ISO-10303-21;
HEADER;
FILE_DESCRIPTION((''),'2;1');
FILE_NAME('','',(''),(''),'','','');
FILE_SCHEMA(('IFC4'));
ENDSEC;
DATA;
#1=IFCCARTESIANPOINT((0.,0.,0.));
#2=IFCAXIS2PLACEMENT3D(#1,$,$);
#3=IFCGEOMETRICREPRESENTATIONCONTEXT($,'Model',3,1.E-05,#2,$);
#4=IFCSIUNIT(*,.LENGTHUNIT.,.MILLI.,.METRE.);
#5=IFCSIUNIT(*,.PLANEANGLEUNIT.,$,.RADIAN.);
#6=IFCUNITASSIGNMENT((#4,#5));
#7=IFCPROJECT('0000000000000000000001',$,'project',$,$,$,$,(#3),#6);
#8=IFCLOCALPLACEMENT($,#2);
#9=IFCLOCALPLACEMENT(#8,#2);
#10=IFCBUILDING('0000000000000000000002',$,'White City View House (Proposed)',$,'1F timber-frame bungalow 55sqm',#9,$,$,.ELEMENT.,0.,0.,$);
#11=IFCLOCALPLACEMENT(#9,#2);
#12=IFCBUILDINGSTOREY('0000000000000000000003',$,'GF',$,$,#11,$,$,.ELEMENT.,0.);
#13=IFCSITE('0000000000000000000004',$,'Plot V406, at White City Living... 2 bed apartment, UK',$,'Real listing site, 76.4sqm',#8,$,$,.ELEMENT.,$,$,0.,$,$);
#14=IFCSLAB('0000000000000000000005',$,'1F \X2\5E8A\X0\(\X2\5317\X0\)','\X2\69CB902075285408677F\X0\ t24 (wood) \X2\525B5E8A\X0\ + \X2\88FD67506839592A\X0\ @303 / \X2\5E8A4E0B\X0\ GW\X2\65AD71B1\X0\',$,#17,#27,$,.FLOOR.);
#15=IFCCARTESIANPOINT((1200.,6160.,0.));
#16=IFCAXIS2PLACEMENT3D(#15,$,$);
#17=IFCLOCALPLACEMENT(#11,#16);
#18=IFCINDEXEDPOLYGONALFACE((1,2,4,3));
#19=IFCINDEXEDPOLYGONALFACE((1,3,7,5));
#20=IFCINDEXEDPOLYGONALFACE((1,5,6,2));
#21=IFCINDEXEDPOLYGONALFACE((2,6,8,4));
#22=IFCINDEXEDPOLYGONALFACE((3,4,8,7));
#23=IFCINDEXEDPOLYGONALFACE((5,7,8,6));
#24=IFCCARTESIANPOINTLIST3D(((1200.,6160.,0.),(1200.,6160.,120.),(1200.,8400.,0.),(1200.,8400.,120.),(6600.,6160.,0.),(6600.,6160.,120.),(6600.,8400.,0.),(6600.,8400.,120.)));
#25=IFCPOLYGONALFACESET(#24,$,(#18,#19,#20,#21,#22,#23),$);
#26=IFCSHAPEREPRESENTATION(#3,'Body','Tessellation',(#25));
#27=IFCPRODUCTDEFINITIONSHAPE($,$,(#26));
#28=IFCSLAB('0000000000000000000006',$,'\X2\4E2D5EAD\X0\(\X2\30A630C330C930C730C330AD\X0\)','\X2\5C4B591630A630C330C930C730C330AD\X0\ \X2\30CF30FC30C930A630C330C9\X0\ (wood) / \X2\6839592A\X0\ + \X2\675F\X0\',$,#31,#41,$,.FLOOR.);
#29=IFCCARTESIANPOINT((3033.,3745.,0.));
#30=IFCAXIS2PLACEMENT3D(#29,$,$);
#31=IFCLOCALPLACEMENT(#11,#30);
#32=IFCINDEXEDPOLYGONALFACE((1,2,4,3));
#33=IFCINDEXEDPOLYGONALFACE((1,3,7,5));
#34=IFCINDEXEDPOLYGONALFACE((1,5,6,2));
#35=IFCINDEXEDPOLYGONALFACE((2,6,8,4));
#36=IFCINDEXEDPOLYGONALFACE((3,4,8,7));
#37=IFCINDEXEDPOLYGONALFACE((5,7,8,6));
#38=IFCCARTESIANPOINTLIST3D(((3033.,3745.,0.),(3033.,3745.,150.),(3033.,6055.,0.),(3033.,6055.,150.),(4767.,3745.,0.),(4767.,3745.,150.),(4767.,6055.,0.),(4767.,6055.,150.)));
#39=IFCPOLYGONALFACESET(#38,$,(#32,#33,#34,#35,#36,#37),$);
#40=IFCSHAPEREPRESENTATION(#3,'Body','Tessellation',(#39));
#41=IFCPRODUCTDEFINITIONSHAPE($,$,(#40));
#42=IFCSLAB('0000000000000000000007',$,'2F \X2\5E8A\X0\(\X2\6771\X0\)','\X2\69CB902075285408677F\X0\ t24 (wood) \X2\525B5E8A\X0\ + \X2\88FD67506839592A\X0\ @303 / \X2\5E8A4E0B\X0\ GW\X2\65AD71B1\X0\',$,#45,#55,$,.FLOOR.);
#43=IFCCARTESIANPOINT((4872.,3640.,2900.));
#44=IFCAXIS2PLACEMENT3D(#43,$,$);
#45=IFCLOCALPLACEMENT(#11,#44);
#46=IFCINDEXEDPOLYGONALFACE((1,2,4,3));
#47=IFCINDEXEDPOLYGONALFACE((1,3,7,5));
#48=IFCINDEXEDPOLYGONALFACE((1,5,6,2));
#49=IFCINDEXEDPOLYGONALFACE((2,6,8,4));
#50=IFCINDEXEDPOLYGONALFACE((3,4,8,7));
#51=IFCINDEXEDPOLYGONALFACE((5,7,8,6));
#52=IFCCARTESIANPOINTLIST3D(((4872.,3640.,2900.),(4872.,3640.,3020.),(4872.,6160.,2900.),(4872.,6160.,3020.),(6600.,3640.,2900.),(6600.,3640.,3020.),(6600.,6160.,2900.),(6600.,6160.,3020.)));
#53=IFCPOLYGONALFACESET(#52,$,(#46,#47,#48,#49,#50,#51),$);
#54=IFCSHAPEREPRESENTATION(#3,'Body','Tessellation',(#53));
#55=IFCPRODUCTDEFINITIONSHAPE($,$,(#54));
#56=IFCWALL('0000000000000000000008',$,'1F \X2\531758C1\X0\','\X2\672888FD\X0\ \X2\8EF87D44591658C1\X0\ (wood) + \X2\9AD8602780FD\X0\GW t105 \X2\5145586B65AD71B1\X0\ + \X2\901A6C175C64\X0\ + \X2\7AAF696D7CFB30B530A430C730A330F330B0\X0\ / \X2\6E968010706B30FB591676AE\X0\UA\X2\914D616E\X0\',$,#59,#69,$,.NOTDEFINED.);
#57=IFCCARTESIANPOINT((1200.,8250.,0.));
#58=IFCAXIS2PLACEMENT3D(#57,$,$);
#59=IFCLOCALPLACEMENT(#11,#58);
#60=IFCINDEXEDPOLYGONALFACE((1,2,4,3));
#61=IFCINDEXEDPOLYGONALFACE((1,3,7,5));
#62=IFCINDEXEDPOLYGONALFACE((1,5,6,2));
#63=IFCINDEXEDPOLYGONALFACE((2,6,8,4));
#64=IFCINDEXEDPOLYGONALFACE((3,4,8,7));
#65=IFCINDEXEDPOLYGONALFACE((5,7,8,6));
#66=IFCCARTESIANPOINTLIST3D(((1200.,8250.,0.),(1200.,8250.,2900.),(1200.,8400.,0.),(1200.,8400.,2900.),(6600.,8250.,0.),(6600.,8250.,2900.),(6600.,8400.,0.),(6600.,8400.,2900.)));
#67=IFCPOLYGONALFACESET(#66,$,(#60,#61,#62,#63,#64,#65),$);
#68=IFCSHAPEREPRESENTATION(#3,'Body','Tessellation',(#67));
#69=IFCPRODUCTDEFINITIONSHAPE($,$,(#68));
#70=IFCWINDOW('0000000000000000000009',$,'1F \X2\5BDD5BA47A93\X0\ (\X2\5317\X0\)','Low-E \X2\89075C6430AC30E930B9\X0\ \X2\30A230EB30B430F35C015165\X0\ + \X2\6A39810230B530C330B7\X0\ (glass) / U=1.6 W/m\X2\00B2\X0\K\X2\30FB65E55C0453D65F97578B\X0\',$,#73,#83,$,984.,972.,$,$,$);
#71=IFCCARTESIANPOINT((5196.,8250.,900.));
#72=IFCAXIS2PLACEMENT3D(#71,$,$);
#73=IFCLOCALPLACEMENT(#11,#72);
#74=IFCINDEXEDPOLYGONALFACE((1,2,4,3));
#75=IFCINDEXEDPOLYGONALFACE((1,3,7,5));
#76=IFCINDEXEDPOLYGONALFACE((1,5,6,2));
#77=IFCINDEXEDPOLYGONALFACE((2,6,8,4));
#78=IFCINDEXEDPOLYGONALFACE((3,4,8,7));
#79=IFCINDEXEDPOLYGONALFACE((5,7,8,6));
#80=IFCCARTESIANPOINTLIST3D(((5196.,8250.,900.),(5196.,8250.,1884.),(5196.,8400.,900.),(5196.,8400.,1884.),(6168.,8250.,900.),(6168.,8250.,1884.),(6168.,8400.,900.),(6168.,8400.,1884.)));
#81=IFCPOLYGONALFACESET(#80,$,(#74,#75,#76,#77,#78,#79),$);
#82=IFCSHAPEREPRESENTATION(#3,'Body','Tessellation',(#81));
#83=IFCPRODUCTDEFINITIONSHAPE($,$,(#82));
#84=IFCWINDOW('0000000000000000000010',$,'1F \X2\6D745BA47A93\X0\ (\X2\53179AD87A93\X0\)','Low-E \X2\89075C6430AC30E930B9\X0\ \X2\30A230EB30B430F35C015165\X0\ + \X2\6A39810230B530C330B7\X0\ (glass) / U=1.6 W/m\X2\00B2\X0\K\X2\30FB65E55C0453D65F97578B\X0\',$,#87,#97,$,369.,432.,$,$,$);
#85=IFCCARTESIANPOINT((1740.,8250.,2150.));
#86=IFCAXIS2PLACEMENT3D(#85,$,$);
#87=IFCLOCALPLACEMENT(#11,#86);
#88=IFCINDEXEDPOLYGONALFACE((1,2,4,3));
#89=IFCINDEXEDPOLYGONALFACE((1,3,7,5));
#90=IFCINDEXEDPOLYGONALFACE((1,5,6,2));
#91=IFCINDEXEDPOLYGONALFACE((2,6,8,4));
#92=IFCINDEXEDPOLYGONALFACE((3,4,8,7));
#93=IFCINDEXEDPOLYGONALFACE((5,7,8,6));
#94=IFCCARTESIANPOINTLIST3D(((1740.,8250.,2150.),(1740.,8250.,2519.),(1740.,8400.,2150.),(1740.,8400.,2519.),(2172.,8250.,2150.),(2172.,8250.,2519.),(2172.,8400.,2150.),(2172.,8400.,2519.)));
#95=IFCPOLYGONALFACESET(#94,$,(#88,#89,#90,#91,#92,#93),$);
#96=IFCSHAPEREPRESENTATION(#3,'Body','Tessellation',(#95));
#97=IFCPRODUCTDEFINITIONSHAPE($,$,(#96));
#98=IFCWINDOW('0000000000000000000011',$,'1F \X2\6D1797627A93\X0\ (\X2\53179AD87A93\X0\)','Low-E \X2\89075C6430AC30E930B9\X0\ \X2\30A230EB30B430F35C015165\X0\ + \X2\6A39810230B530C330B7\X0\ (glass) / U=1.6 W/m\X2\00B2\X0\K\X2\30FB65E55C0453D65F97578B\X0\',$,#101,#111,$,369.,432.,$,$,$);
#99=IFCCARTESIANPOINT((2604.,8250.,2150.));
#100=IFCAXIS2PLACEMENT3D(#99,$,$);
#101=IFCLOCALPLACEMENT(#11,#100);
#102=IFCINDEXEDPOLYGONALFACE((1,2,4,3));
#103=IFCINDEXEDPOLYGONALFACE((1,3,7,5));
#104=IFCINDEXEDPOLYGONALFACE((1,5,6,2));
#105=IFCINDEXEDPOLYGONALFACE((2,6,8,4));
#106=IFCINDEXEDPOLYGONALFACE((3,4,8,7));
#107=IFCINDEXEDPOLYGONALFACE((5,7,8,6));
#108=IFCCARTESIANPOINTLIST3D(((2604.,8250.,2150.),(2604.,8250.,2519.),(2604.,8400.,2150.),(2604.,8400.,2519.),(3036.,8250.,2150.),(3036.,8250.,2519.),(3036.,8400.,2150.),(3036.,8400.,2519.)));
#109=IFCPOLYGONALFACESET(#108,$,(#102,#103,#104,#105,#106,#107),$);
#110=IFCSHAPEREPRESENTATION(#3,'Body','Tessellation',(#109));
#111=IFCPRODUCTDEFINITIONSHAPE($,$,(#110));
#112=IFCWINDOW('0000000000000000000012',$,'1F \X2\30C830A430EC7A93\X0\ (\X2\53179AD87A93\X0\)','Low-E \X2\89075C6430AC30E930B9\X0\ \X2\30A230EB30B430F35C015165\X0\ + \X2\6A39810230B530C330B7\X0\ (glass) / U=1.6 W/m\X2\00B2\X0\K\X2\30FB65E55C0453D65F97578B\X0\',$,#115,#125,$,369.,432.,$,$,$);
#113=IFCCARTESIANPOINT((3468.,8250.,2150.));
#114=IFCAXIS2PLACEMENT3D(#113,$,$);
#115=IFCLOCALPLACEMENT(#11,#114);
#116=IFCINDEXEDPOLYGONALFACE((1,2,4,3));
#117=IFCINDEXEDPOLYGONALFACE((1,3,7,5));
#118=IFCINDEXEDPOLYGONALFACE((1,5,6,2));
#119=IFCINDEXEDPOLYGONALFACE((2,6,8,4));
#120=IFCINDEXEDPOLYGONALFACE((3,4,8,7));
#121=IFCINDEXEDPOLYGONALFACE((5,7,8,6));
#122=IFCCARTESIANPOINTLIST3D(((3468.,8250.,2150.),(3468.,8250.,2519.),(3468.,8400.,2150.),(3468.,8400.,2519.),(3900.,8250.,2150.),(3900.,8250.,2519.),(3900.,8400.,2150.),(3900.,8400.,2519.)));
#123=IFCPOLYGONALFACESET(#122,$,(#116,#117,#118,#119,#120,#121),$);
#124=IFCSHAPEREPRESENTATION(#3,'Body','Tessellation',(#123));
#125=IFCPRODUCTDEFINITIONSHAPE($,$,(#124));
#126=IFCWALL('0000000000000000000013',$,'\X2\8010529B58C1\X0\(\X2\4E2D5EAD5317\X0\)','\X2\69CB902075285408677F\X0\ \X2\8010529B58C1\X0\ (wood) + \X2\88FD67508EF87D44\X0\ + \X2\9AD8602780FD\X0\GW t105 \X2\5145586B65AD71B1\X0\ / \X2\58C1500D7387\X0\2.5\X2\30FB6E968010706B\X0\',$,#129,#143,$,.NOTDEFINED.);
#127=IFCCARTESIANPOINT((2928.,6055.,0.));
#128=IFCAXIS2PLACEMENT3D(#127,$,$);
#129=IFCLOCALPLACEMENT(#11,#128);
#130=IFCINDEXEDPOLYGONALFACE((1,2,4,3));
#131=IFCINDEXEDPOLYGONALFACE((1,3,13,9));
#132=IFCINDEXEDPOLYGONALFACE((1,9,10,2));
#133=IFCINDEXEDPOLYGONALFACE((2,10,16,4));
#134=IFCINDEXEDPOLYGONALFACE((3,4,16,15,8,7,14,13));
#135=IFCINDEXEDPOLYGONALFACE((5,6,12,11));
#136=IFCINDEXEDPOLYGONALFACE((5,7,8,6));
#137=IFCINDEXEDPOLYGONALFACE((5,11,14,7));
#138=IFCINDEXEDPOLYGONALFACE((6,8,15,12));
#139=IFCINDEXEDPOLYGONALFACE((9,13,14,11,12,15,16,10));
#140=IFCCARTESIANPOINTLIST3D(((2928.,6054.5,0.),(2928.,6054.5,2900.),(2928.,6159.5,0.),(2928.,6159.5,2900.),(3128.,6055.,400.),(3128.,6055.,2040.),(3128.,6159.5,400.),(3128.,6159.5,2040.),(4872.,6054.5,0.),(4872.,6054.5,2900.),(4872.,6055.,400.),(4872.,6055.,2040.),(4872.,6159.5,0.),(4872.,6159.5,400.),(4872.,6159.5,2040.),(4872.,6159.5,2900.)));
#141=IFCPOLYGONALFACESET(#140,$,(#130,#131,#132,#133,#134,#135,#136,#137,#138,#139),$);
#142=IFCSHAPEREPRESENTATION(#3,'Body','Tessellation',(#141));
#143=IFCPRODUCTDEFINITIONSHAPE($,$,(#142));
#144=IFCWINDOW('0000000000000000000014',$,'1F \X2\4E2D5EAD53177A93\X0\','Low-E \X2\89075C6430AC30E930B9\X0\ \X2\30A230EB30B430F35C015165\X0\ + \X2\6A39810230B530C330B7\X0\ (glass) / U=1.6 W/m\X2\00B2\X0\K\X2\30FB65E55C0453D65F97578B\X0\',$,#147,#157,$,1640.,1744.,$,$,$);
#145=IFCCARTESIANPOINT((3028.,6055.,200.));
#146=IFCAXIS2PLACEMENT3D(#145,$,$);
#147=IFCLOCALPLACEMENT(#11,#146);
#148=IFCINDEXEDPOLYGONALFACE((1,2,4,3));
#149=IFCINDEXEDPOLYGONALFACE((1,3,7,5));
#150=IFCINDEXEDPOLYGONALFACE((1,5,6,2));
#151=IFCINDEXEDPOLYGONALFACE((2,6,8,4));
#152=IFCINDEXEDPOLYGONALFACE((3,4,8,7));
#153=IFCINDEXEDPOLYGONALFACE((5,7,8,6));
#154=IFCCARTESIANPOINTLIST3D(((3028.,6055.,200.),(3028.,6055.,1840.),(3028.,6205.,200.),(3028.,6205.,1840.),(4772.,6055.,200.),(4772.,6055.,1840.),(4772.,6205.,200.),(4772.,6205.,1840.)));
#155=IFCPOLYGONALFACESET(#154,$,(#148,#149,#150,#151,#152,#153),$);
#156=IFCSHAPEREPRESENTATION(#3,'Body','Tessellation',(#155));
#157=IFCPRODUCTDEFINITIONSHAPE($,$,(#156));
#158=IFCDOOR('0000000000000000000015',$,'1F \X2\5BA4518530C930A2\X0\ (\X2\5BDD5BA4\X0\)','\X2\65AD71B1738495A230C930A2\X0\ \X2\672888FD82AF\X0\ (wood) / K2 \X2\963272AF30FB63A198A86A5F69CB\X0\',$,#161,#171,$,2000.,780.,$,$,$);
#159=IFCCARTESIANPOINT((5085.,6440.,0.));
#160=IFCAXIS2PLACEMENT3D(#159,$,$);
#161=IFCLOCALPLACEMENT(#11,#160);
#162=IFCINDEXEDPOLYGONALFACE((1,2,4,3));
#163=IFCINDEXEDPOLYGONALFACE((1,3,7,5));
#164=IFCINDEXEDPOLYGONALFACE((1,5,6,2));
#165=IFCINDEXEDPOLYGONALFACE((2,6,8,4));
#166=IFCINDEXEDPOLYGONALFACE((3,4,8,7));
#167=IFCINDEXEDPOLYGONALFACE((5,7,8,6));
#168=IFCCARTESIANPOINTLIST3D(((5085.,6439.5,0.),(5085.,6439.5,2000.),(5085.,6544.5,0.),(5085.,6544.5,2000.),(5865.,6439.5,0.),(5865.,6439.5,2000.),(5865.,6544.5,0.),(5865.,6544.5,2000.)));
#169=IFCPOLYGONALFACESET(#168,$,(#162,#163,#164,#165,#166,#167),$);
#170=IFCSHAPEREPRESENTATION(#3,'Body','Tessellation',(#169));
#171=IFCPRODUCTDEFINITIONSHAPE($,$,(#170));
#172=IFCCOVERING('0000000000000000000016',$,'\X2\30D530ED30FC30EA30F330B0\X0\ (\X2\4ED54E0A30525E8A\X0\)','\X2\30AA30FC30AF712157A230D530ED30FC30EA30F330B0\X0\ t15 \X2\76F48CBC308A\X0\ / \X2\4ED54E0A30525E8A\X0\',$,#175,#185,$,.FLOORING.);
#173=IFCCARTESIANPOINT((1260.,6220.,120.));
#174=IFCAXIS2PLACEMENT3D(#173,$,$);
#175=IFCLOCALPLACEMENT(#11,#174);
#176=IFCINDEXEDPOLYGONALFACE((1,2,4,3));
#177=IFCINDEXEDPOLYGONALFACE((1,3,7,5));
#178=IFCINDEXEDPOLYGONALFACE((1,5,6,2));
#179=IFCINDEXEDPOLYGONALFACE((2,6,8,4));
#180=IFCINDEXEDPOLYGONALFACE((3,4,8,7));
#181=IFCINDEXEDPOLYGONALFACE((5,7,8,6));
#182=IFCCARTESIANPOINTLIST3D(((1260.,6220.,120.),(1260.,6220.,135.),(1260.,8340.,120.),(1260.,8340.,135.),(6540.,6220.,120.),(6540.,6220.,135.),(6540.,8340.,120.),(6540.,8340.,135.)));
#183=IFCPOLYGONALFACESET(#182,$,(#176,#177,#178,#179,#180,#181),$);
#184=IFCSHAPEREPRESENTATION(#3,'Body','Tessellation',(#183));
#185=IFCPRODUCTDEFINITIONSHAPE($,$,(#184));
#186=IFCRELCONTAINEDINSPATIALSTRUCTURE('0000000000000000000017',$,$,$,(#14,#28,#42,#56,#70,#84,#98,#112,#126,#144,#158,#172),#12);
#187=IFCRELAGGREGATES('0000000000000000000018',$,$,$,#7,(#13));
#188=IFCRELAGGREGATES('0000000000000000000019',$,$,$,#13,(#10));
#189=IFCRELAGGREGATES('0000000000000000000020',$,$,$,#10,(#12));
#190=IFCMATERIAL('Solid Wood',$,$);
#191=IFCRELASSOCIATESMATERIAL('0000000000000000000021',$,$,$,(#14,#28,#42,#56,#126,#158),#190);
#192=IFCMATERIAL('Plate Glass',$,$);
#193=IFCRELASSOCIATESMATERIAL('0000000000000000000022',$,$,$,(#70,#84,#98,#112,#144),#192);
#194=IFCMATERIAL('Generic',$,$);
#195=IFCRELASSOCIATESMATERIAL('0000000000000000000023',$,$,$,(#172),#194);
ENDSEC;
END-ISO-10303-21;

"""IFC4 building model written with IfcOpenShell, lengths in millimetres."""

from ifc_helpers import new_model, si_unit, frame, frame_2d, origin, place, context, project, spatial, rectangle, extrude, material, element, fill, save


model = new_model("IFC4")

# Units and contexts
model_context = context("Model", 3, precision=1e-05, world=origin())
ifc_project = project(units=[si_unit("LENGTHUNIT", "METRE", prefix="MILLI"), si_unit("PLANEANGLEUNIT", "RADIAN")], contexts=[model_context])

# Site, building, storey
site_placement = place(None, origin())
site = spatial("IfcSite", under=ifc_project, at=site_placement, Name="Plot V406, at White City Living... 2 bed apartment, UK", ObjectType="Real listing site, 76.4sqm", CompositionType="ELEMENT", RefElevation=0.0)
building_placement = place(site_placement, origin())
building = spatial("IfcBuilding", under=site, at=building_placement, Name="White City View House (Proposed)", ObjectType="1F timber-frame bungalow 55sqm", CompositionType="ELEMENT", ElevationOfRefHeight=0.0, ElevationOfTerrain=0.0)
storey_placement = place(building_placement, origin())
storey = spatial("IfcBuildingStorey", under=building, at=storey_placement, Name="GF", CompositionType="ELEMENT", Elevation=0.0)

# Slabs
ifc_material_1 = material(Name="Solid Wood")
slab_1_placement = place(storey_placement, frame((1200.0, 6160.0, 0.0)))
element("IfcSlab", 1, at=slab_1_placement, inside=storey, material=ifc_material_1, Name="1F 床(北)", Description="構造用合板 t24 (wood) 剛床 + 製材根太 @303 / 床下 GW断熱", PredefinedType="FLOOR", context=model_context, shape_type="SweptSolid", body=[
    extrude(rectangle(XDim=5400.0, YDim=2240.0, at=frame_2d((2700.0, 1120.0))), frame((1200.0, 6160.0, 0.0)), (0.0, 0.0, 1.0), 120.0),
])
slab_2_placement = place(storey_placement, frame((3033.0, 3745.0, 0.0)))
element("IfcSlab", 2, at=slab_2_placement, inside=storey, material=ifc_material_1, Name="中庭(ウッドデッキ)", Description="屋外ウッドデッキ ハードウッド (wood) / 根太 + 束", PredefinedType="FLOOR", context=model_context, shape_type="SweptSolid", body=[
    extrude(rectangle(XDim=1734.0, YDim=2310.0, at=frame_2d((867.0, 1155.0))), frame((3033.0, 3745.0, 0.0)), (0.0, 0.0, 1.0), 150.0),
])
slab_3_placement = place(storey_placement, frame((4872.0, 3640.0, 2900.0)))
element("IfcSlab", 3, at=slab_3_placement, inside=storey, material=ifc_material_1, Name="2F 床(東)", Description="構造用合板 t24 (wood) 剛床 + 製材根太 @303 / 床下 GW断熱", PredefinedType="FLOOR", context=model_context, shape_type="SweptSolid", body=[
    extrude(rectangle(XDim=1728.0, YDim=2520.0, at=frame_2d((864.0, 1260.0))), frame((4872.0, 3640.0, 2900.0)), (0.0, 0.0, 1.0), 120.0),
])

# Wall, openings, windows
wall_1_placement = place(storey_placement, frame((1200.0, 8250.0, 0.0)))
wall_1 = element("IfcWall", 4, at=wall_1_placement, inside=storey, material=ifc_material_1, Name="1F 北壁", Description="木製 軸組外壁 (wood) + 高性能GW t105 充填断熱 + 通気層 + 窯業系サイディング / 準耐火・外皮UA配慮", PredefinedType="NOTDEFINED", context=model_context, shape_type="SweptSolid", body=[
    extrude(rectangle(XDim=5400.0, YDim=150.0, at=frame_2d((2700.0, 75.0))), frame((1200.0, 8250.0, 0.0)), (0.0, 0.0, 1.0), 2900.0),
])
opening_1_placement = place(storey_placement, frame((5196.0, 8250.0, 900.0)))
opening_1 = element("IfcOpeningElement", 5, at=opening_1_placement, cuts=wall_1, PredefinedType="NOTDEFINED", context=model_context, shape_type="SweptSolid", body=[
    extrude(rectangle(XDim=972.0, YDim=150.0, at=frame_2d((486.0, 75.0))), frame((5196.0, 8250.0, 900.0)), (0.0, 0.0, 1.0), 984.0),
])
opening_2_placement = place(storey_placement, frame((1740.0, 8250.0, 2150.0)))
opening_2 = element("IfcOpeningElement", 6, at=opening_2_placement, cuts=wall_1, PredefinedType="NOTDEFINED", context=model_context, shape_type="SweptSolid", body=[
    extrude(rectangle(XDim=432.0, YDim=150.0, at=frame_2d((216.0, 75.0))), frame((1740.0, 8250.0, 2150.0)), (0.0, 0.0, 1.0), 369.0),
])
opening_3_placement = place(storey_placement, frame((2604.0, 8250.0, 2150.0)))
opening_3 = element("IfcOpeningElement", 7, at=opening_3_placement, cuts=wall_1, PredefinedType="NOTDEFINED", context=model_context, shape_type="SweptSolid", body=[
    extrude(rectangle(XDim=432.0, YDim=150.0, at=frame_2d((216.0, 75.0))), frame((2604.0, 8250.0, 2150.0)), (0.0, 0.0, 1.0), 369.0),
])
opening_4_placement = place(storey_placement, frame((3468.0, 8250.0, 2150.0)))
opening_4 = element("IfcOpeningElement", 8, at=opening_4_placement, cuts=wall_1, PredefinedType="NOTDEFINED", context=model_context, shape_type="SweptSolid", body=[
    extrude(rectangle(XDim=432.0, YDim=150.0, at=frame_2d((216.0, 75.0))), frame((3468.0, 8250.0, 2150.0)), (0.0, 0.0, 1.0), 369.0),
])
ifc_material_2 = material(Name="Plate Glass")
window_1_placement = place(storey_placement, frame((5196.0, 8250.0, 900.0)))
window_1 = element("IfcWindow", 9, at=window_1_placement, inside=storey, material=ifc_material_2, Name="1F 寝室窓 (北)", Description="Low-E 複層ガラス アルゴン封入 + 樹脂サッシ (glass) / U=1.6 W/m²K・日射取得型", OverallHeight=984.0, OverallWidth=972.0, context=model_context, shape_type="SweptSolid", body=[
    extrude(rectangle(XDim=972.0, YDim=150.0, at=frame_2d((486.0, 75.0))), frame((5196.0, 8250.0, 900.0)), (0.0, 0.0, 1.0), 984.0),
])
fill(opening_1, window_1)
window_2_placement = place(storey_placement, frame((1740.0, 8250.0, 2150.0)))
window_2 = element("IfcWindow", 10, at=window_2_placement, inside=storey, material=ifc_material_2, Name="1F 浴室窓 (北高窓)", Description="Low-E 複層ガラス アルゴン封入 + 樹脂サッシ (glass) / U=1.6 W/m²K・日射取得型", OverallHeight=369.0, OverallWidth=432.0, context=model_context, shape_type="SweptSolid", body=[
    extrude(rectangle(XDim=432.0, YDim=150.0, at=frame_2d((216.0, 75.0))), frame((1740.0, 8250.0, 2150.0)), (0.0, 0.0, 1.0), 369.0),
])
fill(opening_2, window_2)
window_3_placement = place(storey_placement, frame((2604.0, 8250.0, 2150.0)))
window_3 = element("IfcWindow", 11, at=window_3_placement, inside=storey, material=ifc_material_2, Name="1F 洗面窓 (北高窓)", Description="Low-E 複層ガラス アルゴン封入 + 樹脂サッシ (glass) / U=1.6 W/m²K・日射取得型", OverallHeight=369.0, OverallWidth=432.0, context=model_context, shape_type="SweptSolid", body=[
    extrude(rectangle(XDim=432.0, YDim=150.0, at=frame_2d((216.0, 75.0))), frame((2604.0, 8250.0, 2150.0)), (0.0, 0.0, 1.0), 369.0),
])
fill(opening_3, window_3)
window_4_placement = place(storey_placement, frame((3468.0, 8250.0, 2150.0)))
window_4 = element("IfcWindow", 12, at=window_4_placement, inside=storey, material=ifc_material_2, Name="1F トイレ窓 (北高窓)", Description="Low-E 複層ガラス アルゴン封入 + 樹脂サッシ (glass) / U=1.6 W/m²K・日射取得型", OverallHeight=369.0, OverallWidth=432.0, context=model_context, shape_type="SweptSolid", body=[
    extrude(rectangle(XDim=432.0, YDim=150.0, at=frame_2d((216.0, 75.0))), frame((3468.0, 8250.0, 2150.0)), (0.0, 0.0, 1.0), 369.0),
])
fill(opening_4, window_4)

# Wall, opening, window
wall_2_placement = place(storey_placement, frame((2928.0, 6055.0, 0.0)))
wall_2 = element("IfcWall", 13, at=wall_2_placement, inside=storey, material=ifc_material_1, Name="耐力壁(中庭北)", Description="構造用合板 耐力壁 (wood) + 製材軸組 + 高性能GW t105 充填断熱 / 壁倍率2.5・準耐火", PredefinedType="NOTDEFINED", context=model_context, shape_type="SweptSolid", body=[
    extrude(rectangle(XDim=1944.0, YDim=105.0, at=frame_2d((972.0, 52.0))), frame((2928.0, 6055.0, 0.0)), (0.0, 0.0, 1.0), 2900.0),
])
opening_5_placement = place(storey_placement, frame((3028.0, 6055.0, 200.0)))
opening_5 = element("IfcOpeningElement", 14, at=opening_5_placement, cuts=wall_2, PredefinedType="NOTDEFINED", context=model_context, shape_type="SweptSolid", body=[
    extrude(rectangle(XDim=1744.0, YDim=150.0, at=frame_2d((872.0, 75.0))), frame((3028.0, 6055.0, 200.0)), (0.0, 0.0, 1.0), 1640.0),
])
window_5_placement = place(storey_placement, frame((3028.0, 6055.0, 200.0)))
window_5 = element("IfcWindow", 15, at=window_5_placement, inside=storey, material=ifc_material_2, Name="1F 中庭北窓", Description="Low-E 複層ガラス アルゴン封入 + 樹脂サッシ (glass) / U=1.6 W/m²K・日射取得型", OverallHeight=1640.0, OverallWidth=1744.0, context=model_context, shape_type="SweptSolid", body=[
    extrude(rectangle(XDim=1744.0, YDim=150.0, at=frame_2d((872.0, 75.0))), frame((3028.0, 6055.0, 200.0)), (0.0, 0.0, 1.0), 1640.0),
])
fill(opening_5, window_5)

# Door
door_1_placement = place(storey_placement, frame((5085.0, 6440.0, 0.0)))
element("IfcDoor", 16, at=door_1_placement, inside=storey, material=ifc_material_1, Name="1F 室内ドア (寝室)", Description="断熱玄関ドア 木製芯 (wood) / K2 防犯・採風機構", OverallHeight=2000.0, OverallWidth=780.0, context=model_context, shape_type="SweptSolid", body=[
    extrude(rectangle(XDim=780.0, YDim=105.0, at=frame_2d((390.0, 52.0))), frame((5085.0, 6440.0, 0.0)), (0.0, 0.0, 1.0), 2000.0),
])

# Covering
ifc_material_3 = material(Name="Generic")
covering_1_placement = place(storey_placement, frame((1260.0, 6220.0, 120.0)))
element("IfcCovering", 17, at=covering_1_placement, inside=storey, material=ifc_material_3, Name="フローリング (仕上げ床)", Description="オーク無垢フローリング t15 直貼り / 仕上げ床", PredefinedType="FLOORING", context=model_context, shape_type="SweptSolid", body=[
    extrude(rectangle(XDim=5280.0, YDim=2120.0, at=frame_2d((2640.0, 1060.0))), frame((1260.0, 6220.0, 120.0)), (0.0, 0.0, 1.0), 15.0),
])

save(model, "model.ifc")
